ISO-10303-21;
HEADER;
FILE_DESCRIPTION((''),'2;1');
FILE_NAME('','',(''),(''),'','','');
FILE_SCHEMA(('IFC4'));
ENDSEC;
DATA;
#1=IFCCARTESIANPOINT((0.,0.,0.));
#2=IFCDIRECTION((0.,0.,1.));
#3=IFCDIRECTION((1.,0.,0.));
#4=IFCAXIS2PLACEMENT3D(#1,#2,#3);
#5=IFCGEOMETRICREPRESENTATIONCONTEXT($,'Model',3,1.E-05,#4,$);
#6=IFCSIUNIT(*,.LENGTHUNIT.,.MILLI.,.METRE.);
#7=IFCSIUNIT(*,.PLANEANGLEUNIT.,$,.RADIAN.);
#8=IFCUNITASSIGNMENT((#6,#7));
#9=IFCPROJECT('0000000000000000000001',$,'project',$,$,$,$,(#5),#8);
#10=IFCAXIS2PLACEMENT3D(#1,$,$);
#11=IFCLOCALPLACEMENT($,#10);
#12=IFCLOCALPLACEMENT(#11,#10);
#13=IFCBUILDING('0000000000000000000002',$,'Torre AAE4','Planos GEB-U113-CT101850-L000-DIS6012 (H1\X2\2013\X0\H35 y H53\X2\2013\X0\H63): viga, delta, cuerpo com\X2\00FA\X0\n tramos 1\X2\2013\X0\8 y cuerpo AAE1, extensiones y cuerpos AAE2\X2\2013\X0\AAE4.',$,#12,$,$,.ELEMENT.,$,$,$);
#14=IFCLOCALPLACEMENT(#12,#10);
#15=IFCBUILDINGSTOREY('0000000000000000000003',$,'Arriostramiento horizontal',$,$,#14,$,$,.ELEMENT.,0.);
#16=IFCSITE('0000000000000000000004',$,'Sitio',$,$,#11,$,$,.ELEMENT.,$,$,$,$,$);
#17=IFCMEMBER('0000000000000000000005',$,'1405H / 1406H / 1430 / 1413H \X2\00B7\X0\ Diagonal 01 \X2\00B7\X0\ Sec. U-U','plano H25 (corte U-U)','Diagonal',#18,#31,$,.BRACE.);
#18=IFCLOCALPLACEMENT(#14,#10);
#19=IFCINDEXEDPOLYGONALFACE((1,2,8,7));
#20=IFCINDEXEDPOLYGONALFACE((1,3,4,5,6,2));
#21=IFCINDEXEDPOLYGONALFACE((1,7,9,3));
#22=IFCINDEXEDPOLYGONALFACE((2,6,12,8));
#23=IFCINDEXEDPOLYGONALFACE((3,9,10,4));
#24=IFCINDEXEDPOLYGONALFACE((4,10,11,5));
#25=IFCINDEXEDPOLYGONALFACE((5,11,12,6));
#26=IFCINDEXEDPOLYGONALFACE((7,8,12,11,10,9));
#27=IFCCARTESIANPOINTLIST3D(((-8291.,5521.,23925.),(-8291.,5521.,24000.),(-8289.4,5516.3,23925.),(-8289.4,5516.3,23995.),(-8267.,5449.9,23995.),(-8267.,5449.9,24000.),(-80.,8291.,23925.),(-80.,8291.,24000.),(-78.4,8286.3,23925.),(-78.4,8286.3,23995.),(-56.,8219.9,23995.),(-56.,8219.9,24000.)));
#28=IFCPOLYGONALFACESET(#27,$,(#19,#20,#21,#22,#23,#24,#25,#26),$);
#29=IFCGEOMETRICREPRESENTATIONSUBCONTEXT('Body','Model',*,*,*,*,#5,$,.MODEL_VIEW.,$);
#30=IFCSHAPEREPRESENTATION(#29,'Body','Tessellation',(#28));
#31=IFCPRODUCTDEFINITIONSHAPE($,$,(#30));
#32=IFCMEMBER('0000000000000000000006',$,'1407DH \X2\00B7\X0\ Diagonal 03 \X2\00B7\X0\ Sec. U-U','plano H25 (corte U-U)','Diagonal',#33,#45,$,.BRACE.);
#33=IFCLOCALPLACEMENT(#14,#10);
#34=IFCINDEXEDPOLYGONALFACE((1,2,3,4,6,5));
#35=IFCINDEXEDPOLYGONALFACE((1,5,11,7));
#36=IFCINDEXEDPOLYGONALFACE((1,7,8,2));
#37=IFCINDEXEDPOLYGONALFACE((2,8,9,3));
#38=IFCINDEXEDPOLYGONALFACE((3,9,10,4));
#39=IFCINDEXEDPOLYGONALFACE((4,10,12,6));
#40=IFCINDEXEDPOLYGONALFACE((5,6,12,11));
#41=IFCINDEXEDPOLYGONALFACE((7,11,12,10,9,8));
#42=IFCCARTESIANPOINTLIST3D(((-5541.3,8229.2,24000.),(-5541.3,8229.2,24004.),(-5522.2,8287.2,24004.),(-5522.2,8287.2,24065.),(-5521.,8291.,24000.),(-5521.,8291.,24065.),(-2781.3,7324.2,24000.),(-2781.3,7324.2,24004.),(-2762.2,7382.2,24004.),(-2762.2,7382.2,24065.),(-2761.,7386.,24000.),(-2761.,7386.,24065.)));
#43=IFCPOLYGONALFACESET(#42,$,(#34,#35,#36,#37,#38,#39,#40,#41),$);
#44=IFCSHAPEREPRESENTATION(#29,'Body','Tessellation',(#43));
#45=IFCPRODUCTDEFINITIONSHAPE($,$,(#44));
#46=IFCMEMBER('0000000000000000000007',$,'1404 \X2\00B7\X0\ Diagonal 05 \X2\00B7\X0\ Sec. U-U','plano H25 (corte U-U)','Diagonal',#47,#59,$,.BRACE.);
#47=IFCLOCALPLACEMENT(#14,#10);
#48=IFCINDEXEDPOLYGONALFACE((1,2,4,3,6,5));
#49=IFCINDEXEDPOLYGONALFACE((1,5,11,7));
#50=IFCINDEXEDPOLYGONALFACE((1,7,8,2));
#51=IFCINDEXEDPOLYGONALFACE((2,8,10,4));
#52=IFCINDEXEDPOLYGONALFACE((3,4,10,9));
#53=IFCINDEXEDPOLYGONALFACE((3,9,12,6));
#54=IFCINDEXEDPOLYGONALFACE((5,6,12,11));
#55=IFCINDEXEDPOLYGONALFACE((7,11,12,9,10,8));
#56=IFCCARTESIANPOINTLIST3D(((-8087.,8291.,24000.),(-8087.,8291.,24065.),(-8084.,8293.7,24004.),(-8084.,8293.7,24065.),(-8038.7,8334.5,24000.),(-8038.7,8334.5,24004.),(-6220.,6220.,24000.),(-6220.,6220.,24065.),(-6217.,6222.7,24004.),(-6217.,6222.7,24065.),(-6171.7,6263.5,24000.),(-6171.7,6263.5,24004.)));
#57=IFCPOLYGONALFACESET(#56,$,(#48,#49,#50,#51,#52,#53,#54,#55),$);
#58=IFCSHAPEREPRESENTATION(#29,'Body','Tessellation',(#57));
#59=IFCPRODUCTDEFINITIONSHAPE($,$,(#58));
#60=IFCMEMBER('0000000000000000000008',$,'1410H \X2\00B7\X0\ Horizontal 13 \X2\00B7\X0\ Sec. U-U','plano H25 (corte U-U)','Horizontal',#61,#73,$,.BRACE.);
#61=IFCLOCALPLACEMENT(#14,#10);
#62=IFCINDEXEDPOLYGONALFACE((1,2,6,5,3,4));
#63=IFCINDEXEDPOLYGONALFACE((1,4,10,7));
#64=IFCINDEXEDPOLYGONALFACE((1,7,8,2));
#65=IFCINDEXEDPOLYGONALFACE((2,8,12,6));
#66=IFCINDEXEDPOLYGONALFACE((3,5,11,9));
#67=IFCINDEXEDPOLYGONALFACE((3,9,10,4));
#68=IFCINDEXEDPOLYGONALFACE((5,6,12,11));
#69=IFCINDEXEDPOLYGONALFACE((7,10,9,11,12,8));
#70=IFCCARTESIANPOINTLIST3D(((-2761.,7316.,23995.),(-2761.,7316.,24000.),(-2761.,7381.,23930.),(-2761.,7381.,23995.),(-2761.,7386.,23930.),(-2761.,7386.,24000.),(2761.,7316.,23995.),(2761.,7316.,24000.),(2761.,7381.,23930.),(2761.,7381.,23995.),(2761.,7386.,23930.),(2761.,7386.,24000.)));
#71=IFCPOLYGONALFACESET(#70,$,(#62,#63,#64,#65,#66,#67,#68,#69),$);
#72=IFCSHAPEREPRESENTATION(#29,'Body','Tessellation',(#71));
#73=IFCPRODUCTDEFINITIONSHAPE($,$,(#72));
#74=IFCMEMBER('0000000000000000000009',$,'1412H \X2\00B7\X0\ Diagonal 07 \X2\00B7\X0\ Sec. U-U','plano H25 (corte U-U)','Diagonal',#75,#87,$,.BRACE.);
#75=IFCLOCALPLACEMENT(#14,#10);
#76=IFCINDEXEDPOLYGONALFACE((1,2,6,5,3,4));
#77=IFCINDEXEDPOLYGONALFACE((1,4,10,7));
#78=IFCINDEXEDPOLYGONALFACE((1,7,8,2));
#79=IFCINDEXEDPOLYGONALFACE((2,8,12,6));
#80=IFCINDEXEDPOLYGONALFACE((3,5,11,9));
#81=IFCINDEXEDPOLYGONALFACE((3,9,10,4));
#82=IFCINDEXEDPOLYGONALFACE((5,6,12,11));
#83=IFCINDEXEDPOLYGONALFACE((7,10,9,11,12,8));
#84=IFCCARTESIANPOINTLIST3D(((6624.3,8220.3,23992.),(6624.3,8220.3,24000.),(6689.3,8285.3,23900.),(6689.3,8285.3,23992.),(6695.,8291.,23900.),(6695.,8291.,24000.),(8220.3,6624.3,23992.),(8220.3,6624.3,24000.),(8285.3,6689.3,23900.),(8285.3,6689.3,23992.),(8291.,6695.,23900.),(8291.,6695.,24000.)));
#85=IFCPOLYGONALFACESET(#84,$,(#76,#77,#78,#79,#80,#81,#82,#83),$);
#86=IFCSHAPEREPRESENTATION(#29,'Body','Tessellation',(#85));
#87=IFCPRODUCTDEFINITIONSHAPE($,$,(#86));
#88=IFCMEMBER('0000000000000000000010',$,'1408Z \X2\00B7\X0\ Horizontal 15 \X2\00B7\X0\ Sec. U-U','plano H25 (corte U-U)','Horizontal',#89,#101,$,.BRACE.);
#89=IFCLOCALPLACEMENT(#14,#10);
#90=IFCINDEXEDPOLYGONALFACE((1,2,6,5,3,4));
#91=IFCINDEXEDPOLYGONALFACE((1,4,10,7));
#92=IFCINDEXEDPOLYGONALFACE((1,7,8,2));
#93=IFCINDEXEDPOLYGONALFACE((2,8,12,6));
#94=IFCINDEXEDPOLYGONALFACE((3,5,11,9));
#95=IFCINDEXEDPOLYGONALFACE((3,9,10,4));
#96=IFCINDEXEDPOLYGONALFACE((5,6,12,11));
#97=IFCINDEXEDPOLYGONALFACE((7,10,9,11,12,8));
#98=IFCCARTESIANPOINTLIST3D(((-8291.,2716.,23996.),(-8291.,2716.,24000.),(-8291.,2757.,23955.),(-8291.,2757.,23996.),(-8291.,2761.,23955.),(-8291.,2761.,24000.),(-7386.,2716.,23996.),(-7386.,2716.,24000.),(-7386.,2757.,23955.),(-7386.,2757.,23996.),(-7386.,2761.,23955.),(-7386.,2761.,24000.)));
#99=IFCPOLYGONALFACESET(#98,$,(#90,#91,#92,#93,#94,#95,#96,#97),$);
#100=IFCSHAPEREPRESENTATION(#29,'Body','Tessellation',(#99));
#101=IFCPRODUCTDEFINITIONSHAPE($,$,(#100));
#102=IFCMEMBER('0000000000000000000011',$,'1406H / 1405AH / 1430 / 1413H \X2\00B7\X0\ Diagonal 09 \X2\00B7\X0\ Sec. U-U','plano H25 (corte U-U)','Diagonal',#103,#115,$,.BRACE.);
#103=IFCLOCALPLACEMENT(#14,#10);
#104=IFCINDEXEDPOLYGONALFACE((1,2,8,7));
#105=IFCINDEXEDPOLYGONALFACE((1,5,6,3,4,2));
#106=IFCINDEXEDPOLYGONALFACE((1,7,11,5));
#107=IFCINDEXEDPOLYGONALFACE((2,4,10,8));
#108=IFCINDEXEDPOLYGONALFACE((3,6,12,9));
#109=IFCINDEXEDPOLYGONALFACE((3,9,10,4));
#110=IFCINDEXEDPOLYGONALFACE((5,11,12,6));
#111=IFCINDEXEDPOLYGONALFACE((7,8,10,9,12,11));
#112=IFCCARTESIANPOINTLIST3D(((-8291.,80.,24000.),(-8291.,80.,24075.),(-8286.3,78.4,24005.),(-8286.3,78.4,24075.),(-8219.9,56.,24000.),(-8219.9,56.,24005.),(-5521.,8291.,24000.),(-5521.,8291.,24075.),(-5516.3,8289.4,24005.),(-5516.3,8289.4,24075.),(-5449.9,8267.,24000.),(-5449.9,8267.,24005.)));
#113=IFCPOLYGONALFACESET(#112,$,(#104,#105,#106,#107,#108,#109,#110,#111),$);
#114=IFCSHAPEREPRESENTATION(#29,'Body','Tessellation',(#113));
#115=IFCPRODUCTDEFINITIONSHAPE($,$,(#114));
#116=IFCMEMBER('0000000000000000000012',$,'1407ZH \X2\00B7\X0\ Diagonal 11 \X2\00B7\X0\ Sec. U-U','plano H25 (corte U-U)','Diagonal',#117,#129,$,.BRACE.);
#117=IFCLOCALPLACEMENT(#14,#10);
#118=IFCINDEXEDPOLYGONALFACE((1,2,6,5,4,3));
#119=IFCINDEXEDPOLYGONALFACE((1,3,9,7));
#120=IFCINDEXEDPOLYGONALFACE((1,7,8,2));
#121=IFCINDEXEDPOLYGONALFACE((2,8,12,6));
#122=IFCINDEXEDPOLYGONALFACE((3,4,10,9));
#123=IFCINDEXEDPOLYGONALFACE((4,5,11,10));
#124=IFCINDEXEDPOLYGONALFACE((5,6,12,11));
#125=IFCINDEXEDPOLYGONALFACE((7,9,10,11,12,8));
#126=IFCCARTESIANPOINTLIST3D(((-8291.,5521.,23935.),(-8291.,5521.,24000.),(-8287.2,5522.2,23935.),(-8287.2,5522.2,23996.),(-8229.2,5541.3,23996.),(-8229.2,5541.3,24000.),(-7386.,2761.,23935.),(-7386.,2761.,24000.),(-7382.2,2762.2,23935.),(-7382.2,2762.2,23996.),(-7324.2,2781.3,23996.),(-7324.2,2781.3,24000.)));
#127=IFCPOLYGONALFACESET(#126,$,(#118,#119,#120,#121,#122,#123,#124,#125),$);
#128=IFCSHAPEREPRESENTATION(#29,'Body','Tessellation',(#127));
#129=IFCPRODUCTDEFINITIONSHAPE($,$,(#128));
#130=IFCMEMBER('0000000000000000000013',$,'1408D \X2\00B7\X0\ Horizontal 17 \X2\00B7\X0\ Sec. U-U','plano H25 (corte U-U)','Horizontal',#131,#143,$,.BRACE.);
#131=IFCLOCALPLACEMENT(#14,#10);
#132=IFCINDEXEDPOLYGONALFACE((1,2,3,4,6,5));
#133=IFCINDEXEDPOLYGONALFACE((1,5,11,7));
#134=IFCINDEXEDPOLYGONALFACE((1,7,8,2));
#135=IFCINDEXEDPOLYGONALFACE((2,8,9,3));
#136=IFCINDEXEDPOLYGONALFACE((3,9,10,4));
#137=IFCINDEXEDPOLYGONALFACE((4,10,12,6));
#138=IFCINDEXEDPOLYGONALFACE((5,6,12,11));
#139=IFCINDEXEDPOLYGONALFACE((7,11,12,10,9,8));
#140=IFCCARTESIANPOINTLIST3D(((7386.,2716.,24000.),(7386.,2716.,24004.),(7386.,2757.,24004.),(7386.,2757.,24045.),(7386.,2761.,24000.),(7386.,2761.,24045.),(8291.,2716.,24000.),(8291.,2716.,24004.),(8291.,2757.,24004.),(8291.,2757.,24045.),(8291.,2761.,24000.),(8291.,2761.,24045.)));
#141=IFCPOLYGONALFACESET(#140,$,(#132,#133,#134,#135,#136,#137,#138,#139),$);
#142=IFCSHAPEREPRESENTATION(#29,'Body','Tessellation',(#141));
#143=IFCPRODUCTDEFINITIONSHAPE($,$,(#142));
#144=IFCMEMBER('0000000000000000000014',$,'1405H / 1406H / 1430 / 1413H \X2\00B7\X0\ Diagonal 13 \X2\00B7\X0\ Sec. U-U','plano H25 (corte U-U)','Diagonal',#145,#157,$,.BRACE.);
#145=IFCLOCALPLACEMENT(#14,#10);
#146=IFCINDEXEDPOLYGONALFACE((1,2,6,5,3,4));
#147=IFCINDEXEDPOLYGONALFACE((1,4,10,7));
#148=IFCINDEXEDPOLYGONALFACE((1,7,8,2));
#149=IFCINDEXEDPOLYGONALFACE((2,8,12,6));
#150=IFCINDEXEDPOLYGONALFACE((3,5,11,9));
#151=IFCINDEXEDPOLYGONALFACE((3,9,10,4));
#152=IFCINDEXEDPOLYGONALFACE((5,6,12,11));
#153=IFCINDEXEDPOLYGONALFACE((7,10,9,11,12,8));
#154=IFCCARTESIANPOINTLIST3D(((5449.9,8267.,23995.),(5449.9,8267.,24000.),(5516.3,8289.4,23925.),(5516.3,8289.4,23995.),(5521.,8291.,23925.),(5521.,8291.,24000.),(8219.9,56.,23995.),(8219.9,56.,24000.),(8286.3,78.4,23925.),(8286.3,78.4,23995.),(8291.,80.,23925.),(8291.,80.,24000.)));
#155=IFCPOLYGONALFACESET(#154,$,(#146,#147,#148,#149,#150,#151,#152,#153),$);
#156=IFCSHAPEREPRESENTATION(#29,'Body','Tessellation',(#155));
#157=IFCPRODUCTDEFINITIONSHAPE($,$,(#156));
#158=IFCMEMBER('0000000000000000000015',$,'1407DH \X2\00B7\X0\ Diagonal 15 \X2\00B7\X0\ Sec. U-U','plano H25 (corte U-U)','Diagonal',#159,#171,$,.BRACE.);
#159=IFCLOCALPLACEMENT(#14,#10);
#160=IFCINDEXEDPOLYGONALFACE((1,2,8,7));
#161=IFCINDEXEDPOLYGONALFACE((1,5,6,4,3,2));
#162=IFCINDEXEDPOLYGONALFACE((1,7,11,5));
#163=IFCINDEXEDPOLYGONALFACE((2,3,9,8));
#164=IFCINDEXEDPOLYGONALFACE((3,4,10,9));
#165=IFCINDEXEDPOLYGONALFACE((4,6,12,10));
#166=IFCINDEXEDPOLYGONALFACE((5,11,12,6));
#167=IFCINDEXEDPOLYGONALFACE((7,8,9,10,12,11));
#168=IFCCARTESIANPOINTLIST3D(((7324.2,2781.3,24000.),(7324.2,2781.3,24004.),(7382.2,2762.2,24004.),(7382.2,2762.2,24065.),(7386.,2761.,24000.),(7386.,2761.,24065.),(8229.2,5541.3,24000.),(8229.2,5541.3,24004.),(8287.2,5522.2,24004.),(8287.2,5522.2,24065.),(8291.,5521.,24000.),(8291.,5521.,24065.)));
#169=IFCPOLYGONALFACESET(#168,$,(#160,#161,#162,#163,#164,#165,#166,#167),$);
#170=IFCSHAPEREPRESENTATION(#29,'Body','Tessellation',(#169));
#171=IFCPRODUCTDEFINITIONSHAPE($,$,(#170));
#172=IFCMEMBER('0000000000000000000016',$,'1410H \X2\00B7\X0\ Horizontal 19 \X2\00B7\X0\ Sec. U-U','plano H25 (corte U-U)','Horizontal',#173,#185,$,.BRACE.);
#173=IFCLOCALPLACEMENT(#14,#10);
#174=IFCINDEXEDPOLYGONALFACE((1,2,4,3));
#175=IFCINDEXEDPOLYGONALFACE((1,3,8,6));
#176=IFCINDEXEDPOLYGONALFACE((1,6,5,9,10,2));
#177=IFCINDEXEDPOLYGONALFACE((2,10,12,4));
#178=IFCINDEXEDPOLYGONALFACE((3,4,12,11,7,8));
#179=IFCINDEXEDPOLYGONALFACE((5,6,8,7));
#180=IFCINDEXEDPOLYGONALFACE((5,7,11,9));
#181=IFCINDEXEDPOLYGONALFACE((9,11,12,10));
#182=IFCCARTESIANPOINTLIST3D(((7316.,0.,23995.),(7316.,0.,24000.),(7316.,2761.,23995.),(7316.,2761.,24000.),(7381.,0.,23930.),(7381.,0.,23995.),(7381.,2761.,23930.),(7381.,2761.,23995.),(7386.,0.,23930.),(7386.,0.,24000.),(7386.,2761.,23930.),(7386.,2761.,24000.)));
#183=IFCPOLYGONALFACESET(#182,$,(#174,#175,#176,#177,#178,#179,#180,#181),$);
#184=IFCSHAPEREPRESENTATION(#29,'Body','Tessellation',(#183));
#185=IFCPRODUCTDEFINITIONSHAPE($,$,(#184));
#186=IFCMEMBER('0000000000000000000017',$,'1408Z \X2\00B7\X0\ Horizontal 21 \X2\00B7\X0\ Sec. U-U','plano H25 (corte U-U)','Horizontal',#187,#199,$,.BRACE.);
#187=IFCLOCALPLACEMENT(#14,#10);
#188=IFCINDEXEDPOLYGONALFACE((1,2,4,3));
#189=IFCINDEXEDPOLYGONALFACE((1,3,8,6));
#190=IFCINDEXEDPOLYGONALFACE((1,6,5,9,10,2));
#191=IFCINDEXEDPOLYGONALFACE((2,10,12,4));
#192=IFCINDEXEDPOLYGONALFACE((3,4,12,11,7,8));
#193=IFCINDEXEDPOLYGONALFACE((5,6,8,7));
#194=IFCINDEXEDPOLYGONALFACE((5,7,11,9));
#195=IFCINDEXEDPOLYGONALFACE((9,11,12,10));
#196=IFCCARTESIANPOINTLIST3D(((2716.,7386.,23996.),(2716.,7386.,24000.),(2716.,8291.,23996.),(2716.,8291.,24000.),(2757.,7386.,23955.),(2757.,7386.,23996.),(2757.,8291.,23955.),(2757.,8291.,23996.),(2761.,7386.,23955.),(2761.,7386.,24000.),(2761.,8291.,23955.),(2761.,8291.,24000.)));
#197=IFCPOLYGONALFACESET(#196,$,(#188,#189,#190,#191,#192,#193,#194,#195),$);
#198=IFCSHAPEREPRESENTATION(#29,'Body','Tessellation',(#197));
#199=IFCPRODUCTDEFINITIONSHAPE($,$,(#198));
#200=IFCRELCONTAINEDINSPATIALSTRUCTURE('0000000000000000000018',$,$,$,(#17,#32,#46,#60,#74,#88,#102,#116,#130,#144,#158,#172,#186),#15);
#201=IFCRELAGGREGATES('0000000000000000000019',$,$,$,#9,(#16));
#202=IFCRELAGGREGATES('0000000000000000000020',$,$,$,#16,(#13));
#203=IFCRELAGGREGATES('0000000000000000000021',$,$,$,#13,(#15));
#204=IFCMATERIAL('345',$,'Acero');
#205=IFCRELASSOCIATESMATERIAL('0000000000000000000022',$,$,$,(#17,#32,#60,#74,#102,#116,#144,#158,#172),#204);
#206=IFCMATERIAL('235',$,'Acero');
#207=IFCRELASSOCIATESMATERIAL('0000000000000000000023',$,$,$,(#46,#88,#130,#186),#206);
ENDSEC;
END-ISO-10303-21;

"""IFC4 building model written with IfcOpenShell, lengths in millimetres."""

from ifc_helpers import new_model, si_unit, frame, frame_2d, origin, origin_with_axes, place, context, subcontext, project, spatial, l_section, extrude, material, element, save


model = new_model("IFC4")

# Units and contexts
model_context = context("Model", 3, precision=1e-05, world=origin_with_axes())
body_context = subcontext(model_context, "Body", "Model", "MODEL_VIEW")
ifc_project = project(units=[si_unit("LENGTHUNIT", "METRE", prefix="MILLI"), si_unit("PLANEANGLEUNIT", "RADIAN")], contexts=[model_context])

# Site, building, storey
site_placement = place(None, origin())
site = spatial("IfcSite", under=ifc_project, at=site_placement, Name="Sitio", CompositionType="ELEMENT")
building_placement = place(site_placement, origin())
building = spatial("IfcBuilding", under=site, at=building_placement, Name="Torre AAE4", Description="Planos GEB-U113-CT101850-L000-DIS6012 (H1–H35 y H53–H63): viga, delta, cuerpo común tramos 1–8 y cuerpo AAE1, extensiones y cuerpos AAE2–AAE4.", CompositionType="ELEMENT")
storey_placement = place(building_placement, origin())
storey = spatial("IfcBuildingStorey", under=building, at=storey_placement, Name="Arriostramiento horizontal", CompositionType="ELEMENT", Elevation=0.0)

# Members
ifc_material_1 = material(Name="235", Category="Acero")
ifc_material_2 = material(Name="345", Category="Acero")
member_1_placement = place(storey_placement, frame((-8291.0, 5521.0, 24000.0), z_axis=(0.947535, 0.319653, 0.0), x_axis=(0.319653, -0.947535, 0.0)))
element("IfcMember", 1, at=member_1_placement, inside=storey, material=ifc_material_2, Name="1405H / 1406H / 1430 / 1413H · Diagonal 01 · Sec. U-U", Description="plano H25 (corte U-U)", ObjectType="Diagonal", PredefinedType="BRACE", context=body_context, shape_type="SweptSolid", body=[
    extrude(l_section(Depth=75.0, Width=75.0, Thickness=5.0, at=frame_2d((37.5, 37.5))), None, (0.0, 0.0, 1.0), 8665.6),
])
member_2_placement = place(storey_placement, frame((-2761.0, 7386.0, 24000.0), z_axis=(-0.950221, 0.311576, 0.0), x_axis=(-0.311576, -0.950221, 0.0)))
element("IfcMember", 2, at=member_2_placement, inside=storey, material=ifc_material_2, Name="1407DH · Diagonal 03 · Sec. U-U", Description="plano H25 (corte U-U)", ObjectType="Diagonal", PredefinedType="BRACE", context=body_context, shape_type="SweptSolid", body=[
    extrude(l_section(Depth=65.0, Width=65.0, Thickness=4.0, at=frame_2d((32.5, 32.5))), None, (0.0, 0.0, 1.0), 2904.6),
])
member_3_placement = place(storey_placement, frame((-8087.0, 8291.0, 24000.0), z_axis=(0.669579, -0.742741, 0.0), x_axis=(0.742741, 0.669579, 0.0)))
element("IfcMember", 3, at=member_3_placement, inside=storey, material=ifc_material_1, Name="1404 · Diagonal 05 · Sec. U-U", Description="plano H25 (corte U-U)", ObjectType="Diagonal", PredefinedType="BRACE", context=body_context, shape_type="SweptSolid", body=[
    extrude(l_section(Depth=65.0, Width=65.0, Thickness=4.0, at=frame_2d((32.5, 32.5))), None, (0.0, 0.0, 1.0), 2788.3),
])
member_4_placement = place(storey_placement, frame((-2761.0, 7386.0, 24000.0), z_axis=(1.0, 0.0, 0.0), x_axis=(0.0, -1.0, 0.0)))
element("IfcMember", 4, at=member_4_placement, inside=storey, material=ifc_material_2, Name="1410H · Horizontal 13 · Sec. U-U", Description="plano H25 (corte U-U)", ObjectType="Horizontal", PredefinedType="BRACE", context=body_context, shape_type="SweptSolid", body=[
    extrude(l_section(Depth=70.0, Width=70.0, Thickness=5.0, at=frame_2d((35.0, 35.0))), None, (0.0, 0.0, 1.0), 5522.0),
])
member_5_placement = place(storey_placement, frame((6695.0, 8291.0, 24000.0), z_axis=(0.707107, -0.707107, 0.0), x_axis=(-0.707107, -0.707107, 0.0)))
element("IfcMember", 5, at=member_5_placement, inside=storey, material=ifc_material_2, Name="1412H · Diagonal 07 · Sec. U-U", Description="plano H25 (corte U-U)", ObjectType="Diagonal", PredefinedType="BRACE", context=body_context, shape_type="SweptSolid", body=[
    extrude(l_section(Depth=100.0, Width=100.0, Thickness=8.0, at=frame_2d((50.0, 50.0))), None, (0.0, 0.0, 1.0), 2257.1),
])
member_6_placement = place(storey_placement, frame((-8291.0, 2761.0, 24000.0), z_axis=(1.0, 0.0, 0.0), x_axis=(0.0, -1.0, 0.0)))
element("IfcMember", 6, at=member_6_placement, inside=storey, material=ifc_material_1, Name="1408Z · Horizontal 15 · Sec. U-U", Description="plano H25 (corte U-U)", ObjectType="Horizontal", PredefinedType="BRACE", context=body_context, shape_type="SweptSolid", body=[
    extrude(l_section(Depth=45.0, Width=45.0, Thickness=4.0, at=frame_2d((22.5, 22.5))), None, (0.0, 0.0, 1.0), 905.0),
])
member_7_placement = place(storey_placement, frame((-5521.0, 8291.0, 24000.0), z_axis=(-0.319653, -0.947535, 0.0), x_axis=(0.947535, -0.319653, 0.0)))
element("IfcMember", 7, at=member_7_placement, inside=storey, material=ifc_material_2, Name="1406H / 1405AH / 1430 / 1413H · Diagonal 09 · Sec. U-U", Description="plano H25 (corte U-U)", ObjectType="Diagonal", PredefinedType="BRACE", context=body_context, shape_type="SweptSolid", body=[
    extrude(l_section(Depth=75.0, Width=75.0, Thickness=5.0, at=frame_2d((37.5, 37.5))), None, (0.0, 0.0, 1.0), 8665.6),
])
member_8_placement = place(storey_placement, frame((-7386.0, 2761.0, 24000.0), z_axis=(-0.311576, 0.950221, 0.0), x_axis=(0.950221, 0.311576, 0.0)))
element("IfcMember", 8, at=member_8_placement, inside=storey, material=ifc_material_2, Name="1407ZH · Diagonal 11 · Sec. U-U", Description="plano H25 (corte U-U)", ObjectType="Diagonal", PredefinedType="BRACE", context=body_context, shape_type="SweptSolid", body=[
    extrude(l_section(Depth=65.0, Width=65.0, Thickness=4.0, at=frame_2d((32.5, 32.5))), None, (0.0, 0.0, 1.0), 2904.6),
])
member_9_placement = place(storey_placement, frame((8291.0, 2761.0, 24000.0), z_axis=(-1.0, 0.0, 0.0), x_axis=(0.0, -1.0, 0.0)))
element("IfcMember", 9, at=member_9_placement, inside=storey, material=ifc_material_1, Name="1408D · Horizontal 17 · Sec. U-U", Description="plano H25 (corte U-U)", ObjectType="Horizontal", PredefinedType="BRACE", context=body_context, shape_type="SweptSolid", body=[
    extrude(l_section(Depth=45.0, Width=45.0, Thickness=4.0, at=frame_2d((22.5, 22.5))), None, (0.0, 0.0, 1.0), 905.0),
])
member_10_placement = place(storey_placement, frame((5521.0, 8291.0, 24000.0), z_axis=(0.319653, -0.947535, 0.0), x_axis=(-0.947535, -0.319653, 0.0)))
element("IfcMember", 10, at=member_10_placement, inside=storey, material=ifc_material_2, Name="1405H / 1406H / 1430 / 1413H · Diagonal 13 · Sec. U-U", Description="plano H25 (corte U-U)", ObjectType="Diagonal", PredefinedType="BRACE", context=body_context, shape_type="SweptSolid", body=[
    extrude(l_section(Depth=75.0, Width=75.0, Thickness=5.0, at=frame_2d((37.5, 37.5))), None, (0.0, 0.0, 1.0), 8665.6),
])
member_11_placement = place(storey_placement, frame((7386.0, 2761.0, 24000.0), z_axis=(0.311576, 0.950221, 0.0), x_axis=(-0.950221, 0.311576, 0.0)))
element("IfcMember", 11, at=member_11_placement, inside=storey, material=ifc_material_2, Name="1407DH · Diagonal 15 · Sec. U-U", Description="plano H25 (corte U-U)", ObjectType="Diagonal", PredefinedType="BRACE", context=body_context, shape_type="SweptSolid", body=[
    extrude(l_section(Depth=65.0, Width=65.0, Thickness=4.0, at=frame_2d((32.5, 32.5))), None, (0.0, 0.0, 1.0), 2904.6),
])
member_12_placement = place(storey_placement, frame((7386.0, 2761.0, 24000.0), z_axis=(0.0, -1.0, 0.0), x_axis=(-1.0, 0.0, 0.0)))
element("IfcMember", 12, at=member_12_placement, inside=storey, material=ifc_material_2, Name="1410H · Horizontal 19 · Sec. U-U", Description="plano H25 (corte U-U)", ObjectType="Horizontal", PredefinedType="BRACE", context=body_context, shape_type="SweptSolid", body=[
    extrude(l_section(Depth=70.0, Width=70.0, Thickness=5.0, at=frame_2d((35.0, 35.0))), None, (0.0, 0.0, 1.0), 2761.0),
])
member_13_placement = place(storey_placement, frame((2761.0, 8291.0, 24000.0), z_axis=(0.0, -1.0, 0.0), x_axis=(-1.0, 0.0, 0.0)))
element("IfcMember", 13, at=member_13_placement, inside=storey, material=ifc_material_1, Name="1408Z · Horizontal 21 · Sec. U-U", Description="plano H25 (corte U-U)", ObjectType="Horizontal", PredefinedType="BRACE", context=body_context, shape_type="SweptSolid", body=[
    extrude(l_section(Depth=45.0, Width=45.0, Thickness=4.0, at=frame_2d((22.5, 22.5))), None, (0.0, 0.0, 1.0), 905.0),
])

save(model, "model.ifc")
